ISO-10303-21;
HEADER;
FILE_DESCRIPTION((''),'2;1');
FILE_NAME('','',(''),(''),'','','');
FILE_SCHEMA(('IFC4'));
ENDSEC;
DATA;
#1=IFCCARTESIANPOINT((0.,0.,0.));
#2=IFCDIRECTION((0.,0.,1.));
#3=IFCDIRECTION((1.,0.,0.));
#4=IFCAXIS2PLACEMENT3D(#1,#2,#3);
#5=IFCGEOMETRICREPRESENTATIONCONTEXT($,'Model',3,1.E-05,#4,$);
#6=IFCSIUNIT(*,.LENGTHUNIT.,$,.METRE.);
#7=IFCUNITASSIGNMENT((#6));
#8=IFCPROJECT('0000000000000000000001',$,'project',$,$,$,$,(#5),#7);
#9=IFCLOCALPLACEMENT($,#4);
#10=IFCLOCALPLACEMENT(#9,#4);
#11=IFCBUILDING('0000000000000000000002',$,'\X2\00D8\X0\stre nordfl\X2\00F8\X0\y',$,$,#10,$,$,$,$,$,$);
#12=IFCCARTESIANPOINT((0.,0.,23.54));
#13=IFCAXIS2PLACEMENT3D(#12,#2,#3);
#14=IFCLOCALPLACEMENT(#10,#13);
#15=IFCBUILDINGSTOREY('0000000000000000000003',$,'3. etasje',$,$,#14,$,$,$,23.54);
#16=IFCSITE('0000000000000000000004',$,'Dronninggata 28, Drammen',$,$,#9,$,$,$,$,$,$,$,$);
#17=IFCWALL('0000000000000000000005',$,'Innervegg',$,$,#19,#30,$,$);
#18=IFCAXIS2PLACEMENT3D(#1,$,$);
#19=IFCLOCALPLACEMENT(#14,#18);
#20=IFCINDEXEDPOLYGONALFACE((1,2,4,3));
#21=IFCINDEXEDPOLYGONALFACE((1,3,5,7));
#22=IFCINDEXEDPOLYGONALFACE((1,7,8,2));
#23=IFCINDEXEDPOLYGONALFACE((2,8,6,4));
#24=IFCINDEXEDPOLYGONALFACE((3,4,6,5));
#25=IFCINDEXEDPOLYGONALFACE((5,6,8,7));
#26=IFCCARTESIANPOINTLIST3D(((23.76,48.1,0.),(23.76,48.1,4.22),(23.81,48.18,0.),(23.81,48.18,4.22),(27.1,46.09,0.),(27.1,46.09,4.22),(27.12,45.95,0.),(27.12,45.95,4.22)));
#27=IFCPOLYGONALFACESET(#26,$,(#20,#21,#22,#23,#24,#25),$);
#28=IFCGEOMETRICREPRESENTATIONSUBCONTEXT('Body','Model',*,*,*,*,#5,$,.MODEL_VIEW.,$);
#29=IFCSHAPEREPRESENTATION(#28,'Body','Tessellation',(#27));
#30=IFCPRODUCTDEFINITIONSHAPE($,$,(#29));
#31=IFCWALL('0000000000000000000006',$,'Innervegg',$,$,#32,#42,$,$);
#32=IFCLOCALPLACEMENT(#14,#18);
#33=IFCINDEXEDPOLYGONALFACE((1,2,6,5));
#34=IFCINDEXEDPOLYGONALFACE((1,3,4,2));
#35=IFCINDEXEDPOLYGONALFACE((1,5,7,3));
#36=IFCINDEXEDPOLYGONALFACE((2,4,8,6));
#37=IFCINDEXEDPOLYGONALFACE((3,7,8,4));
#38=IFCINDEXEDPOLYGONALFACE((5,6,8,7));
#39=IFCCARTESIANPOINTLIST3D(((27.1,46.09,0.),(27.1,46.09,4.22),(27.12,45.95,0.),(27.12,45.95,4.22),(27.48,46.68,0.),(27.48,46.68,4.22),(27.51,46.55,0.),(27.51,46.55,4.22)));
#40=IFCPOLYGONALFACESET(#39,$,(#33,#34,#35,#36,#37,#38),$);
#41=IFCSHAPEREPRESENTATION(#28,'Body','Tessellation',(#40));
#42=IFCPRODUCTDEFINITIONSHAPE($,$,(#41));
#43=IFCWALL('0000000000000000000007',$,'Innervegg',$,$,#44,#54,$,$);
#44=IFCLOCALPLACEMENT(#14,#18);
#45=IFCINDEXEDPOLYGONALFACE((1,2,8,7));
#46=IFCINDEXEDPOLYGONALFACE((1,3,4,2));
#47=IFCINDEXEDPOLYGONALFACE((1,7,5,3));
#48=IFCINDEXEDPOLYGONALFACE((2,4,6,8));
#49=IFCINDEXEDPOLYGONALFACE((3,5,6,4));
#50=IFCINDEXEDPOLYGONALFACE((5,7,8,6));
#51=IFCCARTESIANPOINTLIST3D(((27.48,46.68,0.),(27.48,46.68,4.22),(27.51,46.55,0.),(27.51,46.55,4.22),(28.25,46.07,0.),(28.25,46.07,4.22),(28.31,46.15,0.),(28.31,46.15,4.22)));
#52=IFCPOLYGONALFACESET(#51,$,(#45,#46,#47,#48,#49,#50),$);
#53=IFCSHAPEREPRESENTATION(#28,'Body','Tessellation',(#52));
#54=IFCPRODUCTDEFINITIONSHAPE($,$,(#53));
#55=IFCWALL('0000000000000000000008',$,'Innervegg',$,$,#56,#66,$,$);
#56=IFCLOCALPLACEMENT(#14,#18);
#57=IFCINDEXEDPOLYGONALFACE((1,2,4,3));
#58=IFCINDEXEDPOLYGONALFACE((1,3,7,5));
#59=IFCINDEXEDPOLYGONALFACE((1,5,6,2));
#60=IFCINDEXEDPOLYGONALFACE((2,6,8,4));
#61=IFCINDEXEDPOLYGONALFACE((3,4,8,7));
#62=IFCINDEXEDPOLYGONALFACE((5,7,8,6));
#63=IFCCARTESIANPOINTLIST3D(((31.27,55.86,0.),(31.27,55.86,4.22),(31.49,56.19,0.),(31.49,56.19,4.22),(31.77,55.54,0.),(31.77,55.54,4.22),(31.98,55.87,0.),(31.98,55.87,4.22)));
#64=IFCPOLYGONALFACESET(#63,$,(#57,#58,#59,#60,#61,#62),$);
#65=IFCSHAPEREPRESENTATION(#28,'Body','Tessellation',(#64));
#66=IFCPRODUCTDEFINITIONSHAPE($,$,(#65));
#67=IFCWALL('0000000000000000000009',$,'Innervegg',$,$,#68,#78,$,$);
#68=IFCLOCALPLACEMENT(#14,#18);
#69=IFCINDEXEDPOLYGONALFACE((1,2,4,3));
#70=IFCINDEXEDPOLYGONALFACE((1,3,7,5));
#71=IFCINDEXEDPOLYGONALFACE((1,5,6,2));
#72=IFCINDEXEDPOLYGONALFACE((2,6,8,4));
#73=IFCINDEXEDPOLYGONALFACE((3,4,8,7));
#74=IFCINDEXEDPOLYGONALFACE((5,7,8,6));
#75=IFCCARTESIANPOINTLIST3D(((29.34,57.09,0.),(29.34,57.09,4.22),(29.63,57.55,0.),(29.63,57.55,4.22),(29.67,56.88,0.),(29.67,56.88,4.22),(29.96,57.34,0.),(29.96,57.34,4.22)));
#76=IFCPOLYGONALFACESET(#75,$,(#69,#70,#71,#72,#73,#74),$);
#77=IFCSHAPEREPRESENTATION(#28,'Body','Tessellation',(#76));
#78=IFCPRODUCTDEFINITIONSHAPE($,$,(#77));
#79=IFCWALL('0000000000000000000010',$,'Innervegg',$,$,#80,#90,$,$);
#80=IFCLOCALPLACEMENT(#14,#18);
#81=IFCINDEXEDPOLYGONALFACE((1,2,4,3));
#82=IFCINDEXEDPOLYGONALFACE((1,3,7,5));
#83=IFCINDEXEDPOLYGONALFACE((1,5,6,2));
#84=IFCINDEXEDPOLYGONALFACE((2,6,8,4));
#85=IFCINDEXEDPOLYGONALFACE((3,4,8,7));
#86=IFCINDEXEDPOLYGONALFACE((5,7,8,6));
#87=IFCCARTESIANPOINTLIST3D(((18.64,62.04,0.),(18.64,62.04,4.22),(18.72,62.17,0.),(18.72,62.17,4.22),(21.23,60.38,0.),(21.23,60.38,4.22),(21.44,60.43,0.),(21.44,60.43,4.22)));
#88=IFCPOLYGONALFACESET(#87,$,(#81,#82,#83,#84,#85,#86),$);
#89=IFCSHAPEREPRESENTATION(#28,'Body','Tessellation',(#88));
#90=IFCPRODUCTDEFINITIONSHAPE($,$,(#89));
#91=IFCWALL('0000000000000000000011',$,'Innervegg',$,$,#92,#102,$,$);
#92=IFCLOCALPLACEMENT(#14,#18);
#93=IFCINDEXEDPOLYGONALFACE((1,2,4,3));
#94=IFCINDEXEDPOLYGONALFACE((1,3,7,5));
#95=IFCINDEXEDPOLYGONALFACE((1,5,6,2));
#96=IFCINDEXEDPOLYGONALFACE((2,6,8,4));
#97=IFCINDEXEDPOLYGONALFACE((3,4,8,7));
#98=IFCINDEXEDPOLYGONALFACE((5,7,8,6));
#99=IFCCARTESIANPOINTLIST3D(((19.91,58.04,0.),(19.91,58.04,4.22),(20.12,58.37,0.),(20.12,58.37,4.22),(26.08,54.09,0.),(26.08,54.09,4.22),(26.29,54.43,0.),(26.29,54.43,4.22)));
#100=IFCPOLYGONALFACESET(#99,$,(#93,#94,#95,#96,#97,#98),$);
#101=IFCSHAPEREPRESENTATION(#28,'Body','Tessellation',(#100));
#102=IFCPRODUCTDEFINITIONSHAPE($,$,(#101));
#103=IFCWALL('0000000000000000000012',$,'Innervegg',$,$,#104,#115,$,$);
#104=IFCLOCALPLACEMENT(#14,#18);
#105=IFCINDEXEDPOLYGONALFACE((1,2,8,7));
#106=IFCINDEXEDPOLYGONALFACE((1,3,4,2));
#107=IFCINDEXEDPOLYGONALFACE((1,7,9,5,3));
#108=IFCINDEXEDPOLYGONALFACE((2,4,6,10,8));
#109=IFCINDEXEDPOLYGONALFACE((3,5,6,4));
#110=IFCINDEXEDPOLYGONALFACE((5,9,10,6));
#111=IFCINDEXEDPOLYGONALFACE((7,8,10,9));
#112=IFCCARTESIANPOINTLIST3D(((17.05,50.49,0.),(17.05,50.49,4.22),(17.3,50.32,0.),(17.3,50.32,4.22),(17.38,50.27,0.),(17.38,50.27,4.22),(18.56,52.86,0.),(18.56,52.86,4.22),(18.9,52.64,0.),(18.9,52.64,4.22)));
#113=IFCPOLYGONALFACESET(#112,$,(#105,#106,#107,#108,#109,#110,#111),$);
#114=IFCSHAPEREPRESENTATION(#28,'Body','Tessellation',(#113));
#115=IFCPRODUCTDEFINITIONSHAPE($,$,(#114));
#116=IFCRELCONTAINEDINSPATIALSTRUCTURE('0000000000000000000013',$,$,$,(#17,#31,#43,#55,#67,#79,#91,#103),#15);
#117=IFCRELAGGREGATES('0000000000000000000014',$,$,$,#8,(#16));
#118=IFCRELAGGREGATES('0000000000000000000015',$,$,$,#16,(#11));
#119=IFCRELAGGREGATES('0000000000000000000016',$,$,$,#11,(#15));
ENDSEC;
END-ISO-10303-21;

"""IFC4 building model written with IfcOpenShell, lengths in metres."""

from ifc_helpers import new_model, si_unit, frame, origin_with_axes, place, context, subcontext, project, spatial, polyline, outline, extrude, element, save


model = new_model("IFC4")

# Units and contexts
model_context = context("Model", 3, precision=1e-05, world=origin_with_axes())
body_context = subcontext(model_context, "Body", "Model", "MODEL_VIEW")
ifc_project = project(units=[si_unit("LENGTHUNIT", "METRE")], contexts=[model_context])

# Site, building, storey
site_placement = place(None, origin_with_axes())
site = spatial("IfcSite", under=ifc_project, at=site_placement, Name="Dronninggata 28, Drammen")
building_placement = place(site_placement, origin_with_axes())
building = spatial("IfcBuilding", under=site, at=building_placement, Name="Østre nordfløy")
storey_placement = place(building_placement, frame((0.0, 0.0, 23.54), z_axis=(0.0, 0.0, 1.0), x_axis=(1.0, 0.0, 0.0)))
storey = spatial("IfcBuildingStorey", under=building, at=storey_placement, Name="3. etasje", Elevation=23.54)

# Walls
wall_1_placement = place(storey_placement, frame((0.0, 0.0, -23.54), z_axis=(0.0, 0.0, 1.0), x_axis=(1.0, 0.0, 0.0)))
element("IfcWall", 1, at=wall_1_placement, inside=storey, Name="Innervegg", context=body_context, shape_type="SweptSolid", body=[
    extrude(outline(polyline([(23.76, 48.1), (23.81, 48.18), (27.1, 46.09), (27.12, 45.95), (23.76, 48.1)])), frame((0.0, 0.0, 23.54)), (0.0, 0.0, 1.0), 4.22),
])
wall_2_placement = place(storey_placement, frame((0.0, 0.0, -23.54), z_axis=(0.0, 0.0, 1.0), x_axis=(1.0, 0.0, 0.0)))
element("IfcWall", 2, at=wall_2_placement, inside=storey, Name="Innervegg", context=body_context, shape_type="SweptSolid", body=[
    extrude(outline(polyline([(27.12, 45.95), (27.1, 46.09), (27.48, 46.68), (27.51, 46.55), (27.12, 45.95)])), frame((0.0, 0.0, 23.54)), (0.0, 0.0, 1.0), 4.22),
])
wall_3_placement = place(storey_placement, frame((0.0, 0.0, -23.54), z_axis=(0.0, 0.0, 1.0), x_axis=(1.0, 0.0, 0.0)))
element("IfcWall", 3, at=wall_3_placement, inside=storey, Name="Innervegg", context=body_context, shape_type="SweptSolid", body=[
    extrude(outline(polyline([(27.51, 46.55), (27.48, 46.68), (28.31, 46.15), (28.25, 46.07), (27.51, 46.55)])), frame((0.0, 0.0, 23.54)), (0.0, 0.0, 1.0), 4.22),
])
wall_4_placement = place(storey_placement, frame((0.0, 0.0, -23.54), z_axis=(0.0, 0.0, 1.0), x_axis=(1.0, 0.0, 0.0)))
element("IfcWall", 4, at=wall_4_placement, inside=storey, Name="Innervegg", context=body_context, shape_type="SweptSolid", body=[
    extrude(outline(polyline([(31.49, 56.19), (31.98, 55.87), (31.77, 55.54), (31.27, 55.86), (31.49, 56.19)])), frame((0.0, 0.0, 23.54)), (0.0, 0.0, 1.0), 4.22),
])
wall_5_placement = place(storey_placement, frame((0.0, 0.0, -23.54), z_axis=(0.0, 0.0, 1.0), x_axis=(1.0, 0.0, 0.0)))
element("IfcWall", 5, at=wall_5_placement, inside=storey, Name="Innervegg", context=body_context, shape_type="SweptSolid", body=[
    extrude(outline(polyline([(29.67, 56.88), (29.34, 57.09), (29.63, 57.55), (29.96, 57.34), (29.67, 56.88)])), frame((0.0, 0.0, 23.54)), (0.0, 0.0, 1.0), 4.22),
])
wall_6_placement = place(storey_placement, frame((0.0, 0.0, -23.54), z_axis=(0.0, 0.0, 1.0), x_axis=(1.0, 0.0, 0.0)))
element("IfcWall", 6, at=wall_6_placement, inside=storey, Name="Innervegg", context=body_context, shape_type="SweptSolid", body=[
    extrude(outline(polyline([(21.44, 60.43), (21.23, 60.38), (18.64, 62.04), (18.72, 62.17), (21.44, 60.43)])), frame((0.0, 0.0, 23.54)), (0.0, 0.0, 1.0), 4.22),
])
wall_7_placement = place(storey_placement, frame((0.0, 0.0, -23.54), z_axis=(0.0, 0.0, 1.0), x_axis=(1.0, 0.0, 0.0)))
element("IfcWall", 7, at=wall_7_placement, inside=storey, Name="Innervegg", context=body_context, shape_type="SweptSolid", body=[
    extrude(outline(polyline([(20.12, 58.37), (26.29, 54.43), (26.08, 54.09), (19.91, 58.04), (20.12, 58.37)])), frame((0.0, 0.0, 23.54)), (0.0, 0.0, 1.0), 4.22),
])
wall_8_placement = place(storey_placement, frame((0.0, 0.0, -23.54), z_axis=(0.0, 0.0, 1.0), x_axis=(1.0, 0.0, 0.0)))
element("IfcWall", 8, at=wall_8_placement, inside=storey, Name="Innervegg", context=body_context, shape_type="SweptSolid", body=[
    extrude(outline(polyline([(18.9, 52.64), (17.38, 50.27), (17.3, 50.32), (17.05, 50.49), (18.56, 52.86), (18.9, 52.64)])), frame((0.0, 0.0, 23.54)), (0.0, 0.0, 1.0), 4.22),
])

save(model, "model.ifc")
